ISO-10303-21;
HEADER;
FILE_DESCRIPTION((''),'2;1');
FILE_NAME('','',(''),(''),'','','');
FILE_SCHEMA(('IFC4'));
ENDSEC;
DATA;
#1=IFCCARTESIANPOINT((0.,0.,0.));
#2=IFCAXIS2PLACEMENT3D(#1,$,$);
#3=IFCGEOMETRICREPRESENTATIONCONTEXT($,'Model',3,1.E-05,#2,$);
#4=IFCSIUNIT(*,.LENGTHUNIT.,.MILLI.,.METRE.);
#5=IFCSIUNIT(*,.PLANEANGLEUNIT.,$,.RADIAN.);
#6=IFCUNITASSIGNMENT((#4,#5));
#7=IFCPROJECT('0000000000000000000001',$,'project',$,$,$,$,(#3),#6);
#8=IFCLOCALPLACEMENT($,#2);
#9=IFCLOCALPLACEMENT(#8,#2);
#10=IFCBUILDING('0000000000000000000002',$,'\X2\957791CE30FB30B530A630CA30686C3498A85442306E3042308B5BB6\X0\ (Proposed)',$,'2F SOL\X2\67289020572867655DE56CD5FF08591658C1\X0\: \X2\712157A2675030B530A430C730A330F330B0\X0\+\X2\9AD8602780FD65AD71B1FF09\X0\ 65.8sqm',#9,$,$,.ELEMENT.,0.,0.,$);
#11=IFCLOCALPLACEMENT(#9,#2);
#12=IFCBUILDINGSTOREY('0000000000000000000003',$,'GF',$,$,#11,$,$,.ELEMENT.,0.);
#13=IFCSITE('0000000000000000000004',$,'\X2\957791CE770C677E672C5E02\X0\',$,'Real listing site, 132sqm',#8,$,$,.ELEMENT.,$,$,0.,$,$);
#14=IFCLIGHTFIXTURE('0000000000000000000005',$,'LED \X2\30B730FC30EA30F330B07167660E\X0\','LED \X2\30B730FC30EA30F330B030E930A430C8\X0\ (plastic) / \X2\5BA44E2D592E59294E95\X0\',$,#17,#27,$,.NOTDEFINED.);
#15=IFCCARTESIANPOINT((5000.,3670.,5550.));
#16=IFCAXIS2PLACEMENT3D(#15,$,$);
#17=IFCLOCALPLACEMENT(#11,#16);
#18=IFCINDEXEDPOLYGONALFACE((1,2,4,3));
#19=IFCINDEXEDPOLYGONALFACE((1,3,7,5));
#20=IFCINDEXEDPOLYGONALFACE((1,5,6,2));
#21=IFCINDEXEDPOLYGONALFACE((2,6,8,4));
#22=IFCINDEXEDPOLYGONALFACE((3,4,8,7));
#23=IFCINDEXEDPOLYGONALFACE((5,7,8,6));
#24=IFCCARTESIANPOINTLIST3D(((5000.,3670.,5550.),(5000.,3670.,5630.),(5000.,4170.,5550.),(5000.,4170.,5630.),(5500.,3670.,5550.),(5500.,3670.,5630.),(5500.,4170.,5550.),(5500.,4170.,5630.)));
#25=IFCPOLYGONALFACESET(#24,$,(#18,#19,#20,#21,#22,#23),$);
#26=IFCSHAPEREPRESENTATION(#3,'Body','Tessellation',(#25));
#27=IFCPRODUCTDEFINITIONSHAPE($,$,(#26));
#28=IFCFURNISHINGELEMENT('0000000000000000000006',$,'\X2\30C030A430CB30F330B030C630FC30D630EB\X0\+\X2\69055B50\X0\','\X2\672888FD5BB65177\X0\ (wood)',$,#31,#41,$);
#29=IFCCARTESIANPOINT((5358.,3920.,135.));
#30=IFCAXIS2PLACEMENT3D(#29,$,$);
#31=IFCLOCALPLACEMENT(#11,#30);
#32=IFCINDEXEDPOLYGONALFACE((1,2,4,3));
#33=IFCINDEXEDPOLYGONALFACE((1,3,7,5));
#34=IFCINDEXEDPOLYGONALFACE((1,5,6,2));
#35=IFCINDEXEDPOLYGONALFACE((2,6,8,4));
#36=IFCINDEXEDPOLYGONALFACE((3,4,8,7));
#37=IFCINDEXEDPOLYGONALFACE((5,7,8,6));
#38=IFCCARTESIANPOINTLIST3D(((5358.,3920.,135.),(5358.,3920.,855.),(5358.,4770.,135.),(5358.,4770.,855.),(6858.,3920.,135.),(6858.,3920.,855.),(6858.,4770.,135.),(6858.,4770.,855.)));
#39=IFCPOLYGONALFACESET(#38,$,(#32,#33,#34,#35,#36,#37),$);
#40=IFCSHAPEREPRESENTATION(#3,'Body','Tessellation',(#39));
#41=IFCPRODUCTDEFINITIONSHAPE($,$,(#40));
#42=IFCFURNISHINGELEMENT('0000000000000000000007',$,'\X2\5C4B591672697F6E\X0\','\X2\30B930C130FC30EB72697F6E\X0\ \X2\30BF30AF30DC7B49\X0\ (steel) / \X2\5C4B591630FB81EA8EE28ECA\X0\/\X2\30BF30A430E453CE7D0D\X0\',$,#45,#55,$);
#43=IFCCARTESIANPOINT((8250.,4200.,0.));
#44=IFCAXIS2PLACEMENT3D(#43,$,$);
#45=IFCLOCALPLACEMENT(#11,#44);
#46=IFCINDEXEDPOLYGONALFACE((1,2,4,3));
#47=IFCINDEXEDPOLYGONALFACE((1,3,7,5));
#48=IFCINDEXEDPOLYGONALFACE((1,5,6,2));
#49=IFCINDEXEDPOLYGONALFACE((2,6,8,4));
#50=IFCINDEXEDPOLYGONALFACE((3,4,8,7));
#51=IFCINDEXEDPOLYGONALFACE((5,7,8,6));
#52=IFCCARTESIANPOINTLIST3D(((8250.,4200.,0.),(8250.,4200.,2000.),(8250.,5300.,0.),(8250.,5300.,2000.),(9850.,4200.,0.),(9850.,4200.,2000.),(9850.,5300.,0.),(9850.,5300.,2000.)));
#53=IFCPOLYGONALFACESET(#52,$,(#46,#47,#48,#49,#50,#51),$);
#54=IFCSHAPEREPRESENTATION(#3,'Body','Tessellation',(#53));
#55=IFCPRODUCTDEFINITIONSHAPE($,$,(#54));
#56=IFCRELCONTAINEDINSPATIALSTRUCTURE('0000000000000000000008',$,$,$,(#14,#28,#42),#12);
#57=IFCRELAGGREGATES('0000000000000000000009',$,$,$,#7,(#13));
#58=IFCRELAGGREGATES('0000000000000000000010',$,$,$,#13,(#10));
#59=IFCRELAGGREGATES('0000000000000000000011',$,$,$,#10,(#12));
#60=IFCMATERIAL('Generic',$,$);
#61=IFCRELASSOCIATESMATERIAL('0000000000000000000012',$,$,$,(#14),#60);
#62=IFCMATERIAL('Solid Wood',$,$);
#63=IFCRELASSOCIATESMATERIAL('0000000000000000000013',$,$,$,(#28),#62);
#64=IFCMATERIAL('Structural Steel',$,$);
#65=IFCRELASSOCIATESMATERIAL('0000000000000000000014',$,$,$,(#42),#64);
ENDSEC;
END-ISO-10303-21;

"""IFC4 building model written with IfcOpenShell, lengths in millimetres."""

from ifc_helpers import new_model, si_unit, frame, frame_2d, origin, place, context, project, spatial, rectangle, extrude, material, element, save


model = new_model("IFC4")

# Units and contexts
model_context = context("Model", 3, precision=1e-05, world=origin())
ifc_project = project(units=[si_unit("LENGTHUNIT", "METRE", prefix="MILLI"), si_unit("PLANEANGLEUNIT", "RADIAN")], contexts=[model_context])

# Site, building, storey
site_placement = place(None, origin())
site = spatial("IfcSite", under=ifc_project, at=site_placement, Name="長野県松本市", ObjectType="Real listing site, 132sqm", CompositionType="ELEMENT", RefElevation=0.0)
building_placement = place(site_placement, origin())
building = spatial("IfcBuilding", under=site, at=building_placement, Name="長野・サウナと水風呂のある家 (Proposed)", ObjectType="2F SOL木造在来工法（外壁: 無垢材サイディング+高性能断熱） 65.8sqm", CompositionType="ELEMENT", ElevationOfRefHeight=0.0, ElevationOfTerrain=0.0)
storey_placement = place(building_placement, origin())
storey = spatial("IfcBuildingStorey", under=building, at=storey_placement, Name="GF", CompositionType="ELEMENT", Elevation=0.0)

# Shared definitions
ifc_material_1 = material(Name="Solid Wood")

# Shared definitions
ifc_material_2 = material(Name="Structural Steel")

# Light fixture
ifc_material_3 = material(Name="Generic")
light_fixture_1_placement = place(storey_placement, frame((5000.0, 3670.0, 5550.0)))
element("IfcLightFixture", 1, at=light_fixture_1_placement, inside=storey, material=ifc_material_3, Name="LED シーリング照明", Description="LED シーリングライト (plastic) / 室中央天井", PredefinedType="NOTDEFINED", context=model_context, shape_type="SweptSolid", body=[
    extrude(rectangle(XDim=500.0, YDim=500.0, at=frame_2d((250.0, 250.0))), frame((5000.0, 3670.0, 5550.0)), (0.0, 0.0, 1.0), 80.0),
])

# Furnishing elements
furnishing_1_placement = place(storey_placement, frame((5358.0, 3920.0, 135.0)))
element("IfcFurnishingElement", 2, at=furnishing_1_placement, inside=storey, material=ifc_material_1, Name="ダイニングテーブル+椅子", Description="木製家具 (wood)", context=model_context, shape_type="SweptSolid", body=[
    extrude(rectangle(XDim=1500.0, YDim=850.0, at=frame_2d((750.0, 425.0))), frame((5358.0, 3920.0, 135.0)), (0.0, 0.0, 1.0), 720.0),
])
furnishing_2_placement = place(storey_placement, frame((8250.0, 4200.0, 0.0)))
element("IfcFurnishingElement", 3, at=furnishing_2_placement, inside=storey, material=ifc_material_2, Name="屋外物置", Description="スチール物置 タクボ等 (steel) / 屋外・自転車/タイヤ収納", context=model_context, shape_type="SweptSolid", body=[
    extrude(rectangle(XDim=1600.0, YDim=1100.0, at=frame_2d((800.0, 550.0))), frame((8250.0, 4200.0, 0.0)), (0.0, 0.0, 1.0), 2000.0),
])

save(model, "model.ifc")
